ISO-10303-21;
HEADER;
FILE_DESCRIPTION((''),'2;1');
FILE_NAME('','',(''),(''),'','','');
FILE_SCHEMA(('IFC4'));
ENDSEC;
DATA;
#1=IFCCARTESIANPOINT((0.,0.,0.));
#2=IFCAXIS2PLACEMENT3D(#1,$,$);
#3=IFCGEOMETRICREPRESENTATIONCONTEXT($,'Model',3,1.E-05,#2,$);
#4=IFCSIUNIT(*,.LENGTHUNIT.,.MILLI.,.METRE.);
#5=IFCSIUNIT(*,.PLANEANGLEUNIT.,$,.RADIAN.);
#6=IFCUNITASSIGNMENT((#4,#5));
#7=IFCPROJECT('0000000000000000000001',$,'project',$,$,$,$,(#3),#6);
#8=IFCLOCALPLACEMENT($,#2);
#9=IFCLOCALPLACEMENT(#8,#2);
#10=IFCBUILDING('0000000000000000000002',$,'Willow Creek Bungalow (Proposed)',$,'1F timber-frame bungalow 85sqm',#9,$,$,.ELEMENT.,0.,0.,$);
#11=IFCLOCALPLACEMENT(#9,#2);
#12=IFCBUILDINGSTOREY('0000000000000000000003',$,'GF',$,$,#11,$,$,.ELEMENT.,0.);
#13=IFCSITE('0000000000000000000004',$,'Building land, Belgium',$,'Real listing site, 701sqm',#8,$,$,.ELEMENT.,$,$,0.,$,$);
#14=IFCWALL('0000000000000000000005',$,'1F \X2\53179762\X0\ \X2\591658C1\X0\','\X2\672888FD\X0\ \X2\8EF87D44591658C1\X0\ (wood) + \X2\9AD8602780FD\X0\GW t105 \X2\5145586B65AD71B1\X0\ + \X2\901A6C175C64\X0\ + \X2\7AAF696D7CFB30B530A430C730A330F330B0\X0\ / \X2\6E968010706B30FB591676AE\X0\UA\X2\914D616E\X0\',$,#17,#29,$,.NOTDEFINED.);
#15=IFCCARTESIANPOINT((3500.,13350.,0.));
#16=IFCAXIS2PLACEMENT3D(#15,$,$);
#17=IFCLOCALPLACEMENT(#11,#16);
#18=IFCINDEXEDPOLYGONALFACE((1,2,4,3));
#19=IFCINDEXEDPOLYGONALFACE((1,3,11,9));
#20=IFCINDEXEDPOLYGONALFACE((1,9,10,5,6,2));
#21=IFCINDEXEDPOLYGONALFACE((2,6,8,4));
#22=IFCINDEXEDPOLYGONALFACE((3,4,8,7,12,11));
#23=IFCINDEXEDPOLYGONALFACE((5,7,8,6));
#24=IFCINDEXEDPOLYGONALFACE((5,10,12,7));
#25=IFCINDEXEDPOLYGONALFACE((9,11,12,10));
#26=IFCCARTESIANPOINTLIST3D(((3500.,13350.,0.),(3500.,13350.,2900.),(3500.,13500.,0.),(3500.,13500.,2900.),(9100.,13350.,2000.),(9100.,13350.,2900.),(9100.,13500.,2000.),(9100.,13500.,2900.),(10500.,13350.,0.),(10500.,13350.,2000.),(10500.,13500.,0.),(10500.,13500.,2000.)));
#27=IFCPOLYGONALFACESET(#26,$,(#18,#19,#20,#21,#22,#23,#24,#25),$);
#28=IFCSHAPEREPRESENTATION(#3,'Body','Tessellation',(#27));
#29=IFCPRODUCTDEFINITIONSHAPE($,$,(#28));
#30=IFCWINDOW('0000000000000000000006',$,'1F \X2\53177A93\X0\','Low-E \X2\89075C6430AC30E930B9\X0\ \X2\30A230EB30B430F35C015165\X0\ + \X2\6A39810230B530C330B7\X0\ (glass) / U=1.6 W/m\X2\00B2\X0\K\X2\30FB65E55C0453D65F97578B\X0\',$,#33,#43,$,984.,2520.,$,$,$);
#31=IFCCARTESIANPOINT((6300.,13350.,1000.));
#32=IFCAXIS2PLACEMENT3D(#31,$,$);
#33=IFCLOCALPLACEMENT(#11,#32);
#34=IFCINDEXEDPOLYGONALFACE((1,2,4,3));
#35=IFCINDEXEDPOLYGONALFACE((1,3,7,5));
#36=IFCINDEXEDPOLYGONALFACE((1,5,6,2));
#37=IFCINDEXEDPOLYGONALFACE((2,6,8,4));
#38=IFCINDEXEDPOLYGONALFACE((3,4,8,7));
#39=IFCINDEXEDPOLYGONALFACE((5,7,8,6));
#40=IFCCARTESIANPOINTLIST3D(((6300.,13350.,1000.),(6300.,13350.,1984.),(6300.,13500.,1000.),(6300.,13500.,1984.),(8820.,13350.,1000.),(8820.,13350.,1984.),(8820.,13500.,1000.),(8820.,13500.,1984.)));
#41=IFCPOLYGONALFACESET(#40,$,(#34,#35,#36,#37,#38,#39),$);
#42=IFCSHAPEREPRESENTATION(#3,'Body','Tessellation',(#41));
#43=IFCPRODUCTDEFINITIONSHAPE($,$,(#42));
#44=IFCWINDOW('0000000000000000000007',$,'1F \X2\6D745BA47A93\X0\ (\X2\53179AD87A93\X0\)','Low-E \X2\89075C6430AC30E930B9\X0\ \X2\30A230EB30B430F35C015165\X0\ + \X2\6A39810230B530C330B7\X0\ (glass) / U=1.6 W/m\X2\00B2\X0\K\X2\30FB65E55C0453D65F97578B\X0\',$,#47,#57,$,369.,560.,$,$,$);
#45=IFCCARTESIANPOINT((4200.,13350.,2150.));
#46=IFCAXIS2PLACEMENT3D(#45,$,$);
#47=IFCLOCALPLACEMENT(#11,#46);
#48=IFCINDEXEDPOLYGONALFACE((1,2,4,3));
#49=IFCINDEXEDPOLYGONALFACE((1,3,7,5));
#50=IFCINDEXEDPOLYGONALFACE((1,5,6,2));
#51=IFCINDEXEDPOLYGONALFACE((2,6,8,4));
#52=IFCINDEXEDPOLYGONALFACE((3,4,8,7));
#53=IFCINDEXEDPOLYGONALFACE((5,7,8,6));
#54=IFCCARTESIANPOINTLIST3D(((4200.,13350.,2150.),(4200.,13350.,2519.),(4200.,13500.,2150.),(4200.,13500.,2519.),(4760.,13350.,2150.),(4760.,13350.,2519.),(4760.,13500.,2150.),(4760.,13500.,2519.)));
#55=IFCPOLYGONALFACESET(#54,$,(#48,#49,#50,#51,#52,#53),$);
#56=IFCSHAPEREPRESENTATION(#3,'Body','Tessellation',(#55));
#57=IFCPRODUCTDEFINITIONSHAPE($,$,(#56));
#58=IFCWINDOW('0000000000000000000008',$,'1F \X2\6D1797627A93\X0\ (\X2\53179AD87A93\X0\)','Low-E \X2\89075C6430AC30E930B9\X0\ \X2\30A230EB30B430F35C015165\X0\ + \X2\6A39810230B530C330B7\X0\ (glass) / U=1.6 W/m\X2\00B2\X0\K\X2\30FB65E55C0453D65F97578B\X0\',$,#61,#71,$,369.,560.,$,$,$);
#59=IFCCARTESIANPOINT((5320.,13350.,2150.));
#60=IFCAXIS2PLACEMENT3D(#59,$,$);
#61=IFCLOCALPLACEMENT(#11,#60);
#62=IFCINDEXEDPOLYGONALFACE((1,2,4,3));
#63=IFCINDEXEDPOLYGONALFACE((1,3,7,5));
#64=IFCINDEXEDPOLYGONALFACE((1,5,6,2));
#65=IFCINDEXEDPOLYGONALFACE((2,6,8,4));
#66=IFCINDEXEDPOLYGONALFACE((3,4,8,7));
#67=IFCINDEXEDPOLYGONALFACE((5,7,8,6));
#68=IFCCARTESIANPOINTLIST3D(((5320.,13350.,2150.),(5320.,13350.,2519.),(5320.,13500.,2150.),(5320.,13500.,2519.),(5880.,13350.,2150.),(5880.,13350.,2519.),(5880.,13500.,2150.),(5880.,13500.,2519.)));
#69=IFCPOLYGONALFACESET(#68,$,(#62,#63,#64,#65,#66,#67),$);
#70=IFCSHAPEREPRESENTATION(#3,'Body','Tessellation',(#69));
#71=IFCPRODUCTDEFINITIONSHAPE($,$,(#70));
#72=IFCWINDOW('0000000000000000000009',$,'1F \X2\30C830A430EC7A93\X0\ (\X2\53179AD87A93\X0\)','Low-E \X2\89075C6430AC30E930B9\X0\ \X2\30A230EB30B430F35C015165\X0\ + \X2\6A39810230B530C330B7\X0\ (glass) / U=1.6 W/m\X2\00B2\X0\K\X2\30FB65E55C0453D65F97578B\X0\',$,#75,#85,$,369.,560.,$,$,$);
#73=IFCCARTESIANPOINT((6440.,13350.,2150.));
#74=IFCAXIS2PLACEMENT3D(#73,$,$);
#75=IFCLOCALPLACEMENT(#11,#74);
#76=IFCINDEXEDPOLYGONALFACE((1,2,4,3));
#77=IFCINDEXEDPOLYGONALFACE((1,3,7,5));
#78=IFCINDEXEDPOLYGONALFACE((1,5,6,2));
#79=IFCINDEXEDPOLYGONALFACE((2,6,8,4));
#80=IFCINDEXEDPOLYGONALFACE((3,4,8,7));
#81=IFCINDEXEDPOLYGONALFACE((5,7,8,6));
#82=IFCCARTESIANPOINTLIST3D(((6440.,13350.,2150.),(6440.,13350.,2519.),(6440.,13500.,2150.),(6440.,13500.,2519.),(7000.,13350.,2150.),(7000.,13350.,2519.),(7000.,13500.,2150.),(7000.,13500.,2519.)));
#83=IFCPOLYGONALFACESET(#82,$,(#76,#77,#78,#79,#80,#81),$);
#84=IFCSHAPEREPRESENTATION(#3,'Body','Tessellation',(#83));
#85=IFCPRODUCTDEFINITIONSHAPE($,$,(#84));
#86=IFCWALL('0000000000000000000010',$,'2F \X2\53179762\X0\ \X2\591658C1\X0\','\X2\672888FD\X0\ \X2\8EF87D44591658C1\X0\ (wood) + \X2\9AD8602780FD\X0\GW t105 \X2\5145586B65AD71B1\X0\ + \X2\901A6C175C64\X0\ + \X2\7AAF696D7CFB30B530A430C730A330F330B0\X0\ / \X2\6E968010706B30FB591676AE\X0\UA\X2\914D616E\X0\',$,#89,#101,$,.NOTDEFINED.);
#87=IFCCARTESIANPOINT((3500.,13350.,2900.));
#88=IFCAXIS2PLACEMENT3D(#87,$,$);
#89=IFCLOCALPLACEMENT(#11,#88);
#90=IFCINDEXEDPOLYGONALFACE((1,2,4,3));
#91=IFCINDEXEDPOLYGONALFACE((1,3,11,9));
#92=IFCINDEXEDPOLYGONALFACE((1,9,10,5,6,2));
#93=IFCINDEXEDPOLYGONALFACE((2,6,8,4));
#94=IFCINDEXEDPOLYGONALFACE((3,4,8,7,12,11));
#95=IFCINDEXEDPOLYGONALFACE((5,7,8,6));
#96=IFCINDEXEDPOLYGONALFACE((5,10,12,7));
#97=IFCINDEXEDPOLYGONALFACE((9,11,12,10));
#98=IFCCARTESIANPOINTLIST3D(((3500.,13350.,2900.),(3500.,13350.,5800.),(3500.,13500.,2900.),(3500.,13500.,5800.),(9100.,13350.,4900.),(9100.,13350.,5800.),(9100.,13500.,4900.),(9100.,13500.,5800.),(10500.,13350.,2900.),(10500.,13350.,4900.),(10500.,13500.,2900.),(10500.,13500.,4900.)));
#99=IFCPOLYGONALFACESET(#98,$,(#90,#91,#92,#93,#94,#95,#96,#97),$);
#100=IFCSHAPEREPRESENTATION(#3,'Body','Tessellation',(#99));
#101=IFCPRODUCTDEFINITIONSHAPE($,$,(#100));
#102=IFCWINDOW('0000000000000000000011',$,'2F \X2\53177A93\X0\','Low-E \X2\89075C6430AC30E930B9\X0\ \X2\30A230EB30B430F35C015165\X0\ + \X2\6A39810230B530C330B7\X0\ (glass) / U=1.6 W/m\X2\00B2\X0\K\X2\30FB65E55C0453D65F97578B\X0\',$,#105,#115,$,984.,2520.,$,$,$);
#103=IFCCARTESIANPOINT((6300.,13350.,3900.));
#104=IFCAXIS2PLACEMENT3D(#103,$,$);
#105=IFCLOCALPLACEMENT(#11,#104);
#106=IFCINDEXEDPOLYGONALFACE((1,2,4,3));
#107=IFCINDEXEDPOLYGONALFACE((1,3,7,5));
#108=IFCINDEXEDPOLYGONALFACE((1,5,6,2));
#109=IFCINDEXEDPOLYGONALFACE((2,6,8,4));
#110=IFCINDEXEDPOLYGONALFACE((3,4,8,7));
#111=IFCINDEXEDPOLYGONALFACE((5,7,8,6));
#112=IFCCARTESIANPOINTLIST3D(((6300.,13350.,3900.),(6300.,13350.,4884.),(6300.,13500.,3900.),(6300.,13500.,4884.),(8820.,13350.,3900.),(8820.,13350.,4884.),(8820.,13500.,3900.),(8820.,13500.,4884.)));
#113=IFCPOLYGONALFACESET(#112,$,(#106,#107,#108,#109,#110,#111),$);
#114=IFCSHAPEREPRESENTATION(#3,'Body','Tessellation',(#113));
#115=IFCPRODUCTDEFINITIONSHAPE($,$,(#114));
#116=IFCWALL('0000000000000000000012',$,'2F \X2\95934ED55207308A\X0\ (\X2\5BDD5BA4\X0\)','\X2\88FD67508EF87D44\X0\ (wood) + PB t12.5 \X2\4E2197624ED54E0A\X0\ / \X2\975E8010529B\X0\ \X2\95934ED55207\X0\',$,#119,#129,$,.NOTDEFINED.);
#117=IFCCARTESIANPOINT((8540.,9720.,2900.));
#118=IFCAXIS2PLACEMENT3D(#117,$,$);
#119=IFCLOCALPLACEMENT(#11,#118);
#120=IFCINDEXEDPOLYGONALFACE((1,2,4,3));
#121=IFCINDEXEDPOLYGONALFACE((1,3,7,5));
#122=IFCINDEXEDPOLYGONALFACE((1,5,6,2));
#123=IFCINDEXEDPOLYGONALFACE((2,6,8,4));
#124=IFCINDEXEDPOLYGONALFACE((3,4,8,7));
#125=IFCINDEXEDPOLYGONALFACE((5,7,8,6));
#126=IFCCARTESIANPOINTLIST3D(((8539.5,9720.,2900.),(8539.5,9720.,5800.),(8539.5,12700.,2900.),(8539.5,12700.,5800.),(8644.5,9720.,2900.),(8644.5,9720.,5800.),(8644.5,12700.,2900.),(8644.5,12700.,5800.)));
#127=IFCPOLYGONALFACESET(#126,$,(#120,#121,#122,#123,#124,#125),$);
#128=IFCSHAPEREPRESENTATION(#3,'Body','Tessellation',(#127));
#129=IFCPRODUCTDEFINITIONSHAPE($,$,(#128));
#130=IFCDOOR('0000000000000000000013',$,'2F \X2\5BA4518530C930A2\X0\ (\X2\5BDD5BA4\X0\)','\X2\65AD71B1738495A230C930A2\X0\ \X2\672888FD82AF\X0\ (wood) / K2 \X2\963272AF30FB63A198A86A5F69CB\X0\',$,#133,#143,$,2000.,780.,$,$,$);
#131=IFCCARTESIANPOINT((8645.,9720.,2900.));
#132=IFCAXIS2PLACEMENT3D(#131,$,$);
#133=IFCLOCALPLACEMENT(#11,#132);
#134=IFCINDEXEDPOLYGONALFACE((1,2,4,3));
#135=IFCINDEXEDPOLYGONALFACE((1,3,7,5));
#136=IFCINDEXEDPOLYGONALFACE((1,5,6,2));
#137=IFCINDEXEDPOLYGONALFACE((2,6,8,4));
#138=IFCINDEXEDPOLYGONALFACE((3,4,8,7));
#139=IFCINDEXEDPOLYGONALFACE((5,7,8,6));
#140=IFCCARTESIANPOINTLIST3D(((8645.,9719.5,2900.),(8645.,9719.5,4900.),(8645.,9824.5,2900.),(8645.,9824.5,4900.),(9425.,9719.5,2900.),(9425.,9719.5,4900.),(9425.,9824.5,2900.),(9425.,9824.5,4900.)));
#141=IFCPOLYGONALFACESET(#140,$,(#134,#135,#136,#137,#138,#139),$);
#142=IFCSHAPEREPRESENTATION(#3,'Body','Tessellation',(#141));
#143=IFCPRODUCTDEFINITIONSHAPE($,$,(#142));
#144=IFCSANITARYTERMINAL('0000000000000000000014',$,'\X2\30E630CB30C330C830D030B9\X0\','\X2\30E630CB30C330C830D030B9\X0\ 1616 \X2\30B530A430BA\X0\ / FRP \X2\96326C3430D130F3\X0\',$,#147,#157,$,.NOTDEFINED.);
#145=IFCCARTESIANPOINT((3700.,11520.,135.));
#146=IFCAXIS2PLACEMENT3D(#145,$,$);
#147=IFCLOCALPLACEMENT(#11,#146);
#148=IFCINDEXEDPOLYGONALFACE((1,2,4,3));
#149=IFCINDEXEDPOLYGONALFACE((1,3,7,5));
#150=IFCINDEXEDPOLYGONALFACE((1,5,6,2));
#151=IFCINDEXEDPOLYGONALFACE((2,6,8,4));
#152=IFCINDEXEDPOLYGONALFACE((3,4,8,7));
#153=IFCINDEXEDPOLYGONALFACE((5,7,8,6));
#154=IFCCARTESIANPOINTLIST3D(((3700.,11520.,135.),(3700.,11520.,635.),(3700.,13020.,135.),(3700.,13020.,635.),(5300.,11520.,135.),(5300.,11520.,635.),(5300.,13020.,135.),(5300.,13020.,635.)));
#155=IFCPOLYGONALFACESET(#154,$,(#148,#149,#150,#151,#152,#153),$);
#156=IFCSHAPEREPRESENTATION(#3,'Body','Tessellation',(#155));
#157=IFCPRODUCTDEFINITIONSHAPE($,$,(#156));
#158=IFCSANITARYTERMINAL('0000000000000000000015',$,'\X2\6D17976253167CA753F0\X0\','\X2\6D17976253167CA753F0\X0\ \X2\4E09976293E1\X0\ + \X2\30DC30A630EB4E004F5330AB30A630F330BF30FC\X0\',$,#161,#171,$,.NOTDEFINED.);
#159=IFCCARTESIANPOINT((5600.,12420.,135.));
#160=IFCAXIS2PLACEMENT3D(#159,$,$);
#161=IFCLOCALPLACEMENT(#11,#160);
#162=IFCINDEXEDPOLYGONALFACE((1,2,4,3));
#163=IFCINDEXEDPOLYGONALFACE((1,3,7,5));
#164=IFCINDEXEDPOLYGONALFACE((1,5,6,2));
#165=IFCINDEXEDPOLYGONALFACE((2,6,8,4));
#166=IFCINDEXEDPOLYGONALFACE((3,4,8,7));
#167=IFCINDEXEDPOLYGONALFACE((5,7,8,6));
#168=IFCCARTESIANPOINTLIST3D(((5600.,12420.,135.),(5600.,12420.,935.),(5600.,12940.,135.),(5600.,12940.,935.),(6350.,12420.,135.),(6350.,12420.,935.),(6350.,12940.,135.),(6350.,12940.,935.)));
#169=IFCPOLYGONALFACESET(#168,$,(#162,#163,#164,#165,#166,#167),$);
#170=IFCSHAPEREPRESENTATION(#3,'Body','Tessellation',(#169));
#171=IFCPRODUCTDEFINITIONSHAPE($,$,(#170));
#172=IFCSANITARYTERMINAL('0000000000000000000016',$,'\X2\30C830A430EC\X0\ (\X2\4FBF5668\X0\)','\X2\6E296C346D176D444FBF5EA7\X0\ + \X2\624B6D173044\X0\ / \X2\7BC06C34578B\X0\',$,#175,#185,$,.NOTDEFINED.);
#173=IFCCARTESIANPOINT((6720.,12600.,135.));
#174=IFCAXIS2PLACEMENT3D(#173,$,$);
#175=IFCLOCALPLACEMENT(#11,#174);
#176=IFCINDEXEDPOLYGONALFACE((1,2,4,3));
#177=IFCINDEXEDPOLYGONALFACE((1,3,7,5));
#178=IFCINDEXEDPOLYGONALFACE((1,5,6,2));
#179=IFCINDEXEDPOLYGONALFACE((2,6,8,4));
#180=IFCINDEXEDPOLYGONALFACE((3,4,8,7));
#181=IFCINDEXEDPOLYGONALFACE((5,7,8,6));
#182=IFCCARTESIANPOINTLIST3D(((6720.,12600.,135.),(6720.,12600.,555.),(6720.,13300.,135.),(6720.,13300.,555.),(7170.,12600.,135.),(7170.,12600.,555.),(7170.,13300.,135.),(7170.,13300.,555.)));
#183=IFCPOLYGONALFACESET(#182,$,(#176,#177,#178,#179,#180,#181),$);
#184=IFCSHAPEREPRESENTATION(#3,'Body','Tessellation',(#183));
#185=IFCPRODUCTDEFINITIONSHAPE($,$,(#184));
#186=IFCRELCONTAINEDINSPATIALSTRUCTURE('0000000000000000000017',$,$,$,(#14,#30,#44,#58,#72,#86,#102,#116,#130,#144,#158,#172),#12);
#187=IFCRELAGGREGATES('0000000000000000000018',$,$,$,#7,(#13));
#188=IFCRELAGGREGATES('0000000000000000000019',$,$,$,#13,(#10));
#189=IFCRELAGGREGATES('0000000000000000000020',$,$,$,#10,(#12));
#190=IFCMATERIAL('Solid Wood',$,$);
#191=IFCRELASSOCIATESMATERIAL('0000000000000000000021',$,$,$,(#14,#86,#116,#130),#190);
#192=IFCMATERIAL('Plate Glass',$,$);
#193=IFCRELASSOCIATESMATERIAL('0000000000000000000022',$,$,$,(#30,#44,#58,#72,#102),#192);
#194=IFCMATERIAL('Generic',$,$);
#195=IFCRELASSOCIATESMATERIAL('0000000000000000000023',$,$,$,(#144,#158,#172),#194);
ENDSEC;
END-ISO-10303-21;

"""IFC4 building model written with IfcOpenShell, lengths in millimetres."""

from ifc_helpers import new_model, si_unit, frame, frame_2d, origin, place, context, project, spatial, rectangle, extrude, material, element, fill, save


model = new_model("IFC4")

# Units and contexts
model_context = context("Model", 3, precision=1e-05, world=origin())
ifc_project = project(units=[si_unit("LENGTHUNIT", "METRE", prefix="MILLI"), si_unit("PLANEANGLEUNIT", "RADIAN")], contexts=[model_context])

# Site, building, storey
site_placement = place(None, origin())
site = spatial("IfcSite", under=ifc_project, at=site_placement, Name="Building land, Belgium", ObjectType="Real listing site, 701sqm", CompositionType="ELEMENT", RefElevation=0.0)
building_placement = place(site_placement, origin())
building = spatial("IfcBuilding", under=site, at=building_placement, Name="Willow Creek Bungalow (Proposed)", ObjectType="1F timber-frame bungalow 85sqm", CompositionType="ELEMENT", ElevationOfRefHeight=0.0, ElevationOfTerrain=0.0)
storey_placement = place(building_placement, origin())
storey = spatial("IfcBuildingStorey", under=building, at=storey_placement, Name="GF", CompositionType="ELEMENT", Elevation=0.0)

# Wall, openings, windows
ifc_material_1 = material(Name="Solid Wood")
wall_1_placement = place(storey_placement, frame((3500.0, 13350.0, 0.0)))
wall_1 = element("IfcWall", 1, at=wall_1_placement, inside=storey, material=ifc_material_1, Name="1F 北面 外壁", Description="木製 軸組外壁 (wood) + 高性能GW t105 充填断熱 + 通気層 + 窯業系サイディング / 準耐火・外皮UA配慮", PredefinedType="NOTDEFINED", context=model_context, shape_type="SweptSolid", body=[
    extrude(rectangle(XDim=7000.0, YDim=150.0, at=frame_2d((3500.0, 75.0))), frame((3500.0, 13350.0, 0.0)), (0.0, 0.0, 1.0), 2900.0),
])
opening_1_placement = place(storey_placement, frame((6300.0, 13350.0, 1000.0)))
opening_1 = element("IfcOpeningElement", 2, at=opening_1_placement, cuts=wall_1, PredefinedType="NOTDEFINED", context=model_context, shape_type="SweptSolid", body=[
    extrude(rectangle(XDim=2520.0, YDim=150.0, at=frame_2d((1260.0, 75.0))), frame((6300.0, 13350.0, 1000.0)), (0.0, 0.0, 1.0), 984.0),
])
opening_2_placement = place(storey_placement, frame((4200.0, 13350.0, 2150.0)))
opening_2 = element("IfcOpeningElement", 3, at=opening_2_placement, cuts=wall_1, PredefinedType="NOTDEFINED", context=model_context, shape_type="SweptSolid", body=[
    extrude(rectangle(XDim=560.0, YDim=150.0, at=frame_2d((280.0, 75.0))), frame((4200.0, 13350.0, 2150.0)), (0.0, 0.0, 1.0), 369.0),
])
opening_3_placement = place(storey_placement, frame((5320.0, 13350.0, 2150.0)))
opening_3 = element("IfcOpeningElement", 4, at=opening_3_placement, cuts=wall_1, PredefinedType="NOTDEFINED", context=model_context, shape_type="SweptSolid", body=[
    extrude(rectangle(XDim=560.0, YDim=150.0, at=frame_2d((280.0, 75.0))), frame((5320.0, 13350.0, 2150.0)), (0.0, 0.0, 1.0), 369.0),
])
opening_4_placement = place(storey_placement, frame((6440.0, 13350.0, 2150.0)))
opening_4 = element("IfcOpeningElement", 5, at=opening_4_placement, cuts=wall_1, PredefinedType="NOTDEFINED", context=model_context, shape_type="SweptSolid", body=[
    extrude(rectangle(XDim=560.0, YDim=150.0, at=frame_2d((280.0, 75.0))), frame((6440.0, 13350.0, 2150.0)), (0.0, 0.0, 1.0), 369.0),
])
ifc_material_2 = material(Name="Plate Glass")
window_1_placement = place(storey_placement, frame((6300.0, 13350.0, 1000.0)))
window_1 = element("IfcWindow", 6, at=window_1_placement, inside=storey, material=ifc_material_2, Name="1F 北窓", Description="Low-E 複層ガラス アルゴン封入 + 樹脂サッシ (glass) / U=1.6 W/m²K・日射取得型", OverallHeight=984.0, OverallWidth=2520.0, context=model_context, shape_type="SweptSolid", body=[
    extrude(rectangle(XDim=2520.0, YDim=150.0, at=frame_2d((1260.0, 75.0))), frame((6300.0, 13350.0, 1000.0)), (0.0, 0.0, 1.0), 984.0),
])
fill(opening_1, window_1)
window_2_placement = place(storey_placement, frame((4200.0, 13350.0, 2150.0)))
window_2 = element("IfcWindow", 7, at=window_2_placement, inside=storey, material=ifc_material_2, Name="1F 浴室窓 (北高窓)", Description="Low-E 複層ガラス アルゴン封入 + 樹脂サッシ (glass) / U=1.6 W/m²K・日射取得型", OverallHeight=369.0, OverallWidth=560.0, context=model_context, shape_type="SweptSolid", body=[
    extrude(rectangle(XDim=560.0, YDim=150.0, at=frame_2d((280.0, 75.0))), frame((4200.0, 13350.0, 2150.0)), (0.0, 0.0, 1.0), 369.0),
])
fill(opening_2, window_2)
window_3_placement = place(storey_placement, frame((5320.0, 13350.0, 2150.0)))
window_3 = element("IfcWindow", 8, at=window_3_placement, inside=storey, material=ifc_material_2, Name="1F 洗面窓 (北高窓)", Description="Low-E 複層ガラス アルゴン封入 + 樹脂サッシ (glass) / U=1.6 W/m²K・日射取得型", OverallHeight=369.0, OverallWidth=560.0, context=model_context, shape_type="SweptSolid", body=[
    extrude(rectangle(XDim=560.0, YDim=150.0, at=frame_2d((280.0, 75.0))), frame((5320.0, 13350.0, 2150.0)), (0.0, 0.0, 1.0), 369.0),
])
fill(opening_3, window_3)
window_4_placement = place(storey_placement, frame((6440.0, 13350.0, 2150.0)))
window_4 = element("IfcWindow", 9, at=window_4_placement, inside=storey, material=ifc_material_2, Name="1F トイレ窓 (北高窓)", Description="Low-E 複層ガラス アルゴン封入 + 樹脂サッシ (glass) / U=1.6 W/m²K・日射取得型", OverallHeight=369.0, OverallWidth=560.0, context=model_context, shape_type="SweptSolid", body=[
    extrude(rectangle(XDim=560.0, YDim=150.0, at=frame_2d((280.0, 75.0))), frame((6440.0, 13350.0, 2150.0)), (0.0, 0.0, 1.0), 369.0),
])
fill(opening_4, window_4)

# Wall, opening, window
wall_2_placement = place(storey_placement, frame((3500.0, 13350.0, 2900.0)))
wall_2 = element("IfcWall", 10, at=wall_2_placement, inside=storey, material=ifc_material_1, Name="2F 北面 外壁", Description="木製 軸組外壁 (wood) + 高性能GW t105 充填断熱 + 通気層 + 窯業系サイディング / 準耐火・外皮UA配慮", PredefinedType="NOTDEFINED", context=model_context, shape_type="SweptSolid", body=[
    extrude(rectangle(XDim=7000.0, YDim=150.0, at=frame_2d((3500.0, 75.0))), frame((3500.0, 13350.0, 2900.0)), (0.0, 0.0, 1.0), 2900.0),
])
opening_5_placement = place(storey_placement, frame((6300.0, 13350.0, 3900.0)))
opening_5 = element("IfcOpeningElement", 11, at=opening_5_placement, cuts=wall_2, PredefinedType="NOTDEFINED", context=model_context, shape_type="SweptSolid", body=[
    extrude(rectangle(XDim=2520.0, YDim=150.0, at=frame_2d((1260.0, 75.0))), frame((6300.0, 13350.0, 3900.0)), (0.0, 0.0, 1.0), 984.0),
])
window_5_placement = place(storey_placement, frame((6300.0, 13350.0, 3900.0)))
window_5 = element("IfcWindow", 12, at=window_5_placement, inside=storey, material=ifc_material_2, Name="2F 北窓", Description="Low-E 複層ガラス アルゴン封入 + 樹脂サッシ (glass) / U=1.6 W/m²K・日射取得型", OverallHeight=984.0, OverallWidth=2520.0, context=model_context, shape_type="SweptSolid", body=[
    extrude(rectangle(XDim=2520.0, YDim=150.0, at=frame_2d((1260.0, 75.0))), frame((6300.0, 13350.0, 3900.0)), (0.0, 0.0, 1.0), 984.0),
])
fill(opening_5, window_5)

# Wall
wall_3_placement = place(storey_placement, frame((8540.0, 9720.0, 2900.0)))
element("IfcWall", 13, at=wall_3_placement, inside=storey, material=ifc_material_1, Name="2F 間仕切り (寝室)", Description="製材軸組 (wood) + PB t12.5 両面仕上 / 非耐力 間仕切", PredefinedType="NOTDEFINED", context=model_context, shape_type="SweptSolid", body=[
    extrude(rectangle(XDim=105.0, YDim=2980.0, at=frame_2d((52.0, 1490.0))), frame((8540.0, 9720.0, 2900.0)), (0.0, 0.0, 1.0), 2900.0),
])

# Door
door_1_placement = place(storey_placement, frame((8645.0, 9720.0, 2900.0)))
element("IfcDoor", 14, at=door_1_placement, inside=storey, material=ifc_material_1, Name="2F 室内ドア (寝室)", Description="断熱玄関ドア 木製芯 (wood) / K2 防犯・採風機構", OverallHeight=2000.0, OverallWidth=780.0, context=model_context, shape_type="SweptSolid", body=[
    extrude(rectangle(XDim=780.0, YDim=105.0, at=frame_2d((390.0, 52.0))), frame((8645.0, 9720.0, 2900.0)), (0.0, 0.0, 1.0), 2000.0),
])

# Sanitary terminals
ifc_material_3 = material(Name="Generic")
sanitary_terminal_1_placement = place(storey_placement, frame((3700.0, 11520.0, 135.0)))
element("IfcSanitaryTerminal", 15, at=sanitary_terminal_1_placement, inside=storey, material=ifc_material_3, Name="ユニットバス", Description="ユニットバス 1616 サイズ / FRP 防水パン", PredefinedType="NOTDEFINED", context=model_context, shape_type="SweptSolid", body=[
    extrude(rectangle(XDim=1600.0, YDim=1500.0, at=frame_2d((800.0, 750.0))), frame((3700.0, 11520.0, 135.0)), (0.0, 0.0, 1.0), 500.0),
])
sanitary_terminal_2_placement = place(storey_placement, frame((5600.0, 12420.0, 135.0)))
element("IfcSanitaryTerminal", 16, at=sanitary_terminal_2_placement, inside=storey, material=ifc_material_3, Name="洗面化粧台", Description="洗面化粧台 三面鏡 + ボウル一体カウンター", PredefinedType="NOTDEFINED", context=model_context, shape_type="SweptSolid", body=[
    extrude(rectangle(XDim=750.0, YDim=520.0, at=frame_2d((375.0, 260.0))), frame((5600.0, 12420.0, 135.0)), (0.0, 0.0, 1.0), 800.0),
])
sanitary_terminal_3_placement = place(storey_placement, frame((6720.0, 12600.0, 135.0)))
element("IfcSanitaryTerminal", 17, at=sanitary_terminal_3_placement, inside=storey, material=ifc_material_3, Name="トイレ (便器)", Description="温水洗浄便座 + 手洗い / 節水型", PredefinedType="NOTDEFINED", context=model_context, shape_type="SweptSolid", body=[
    extrude(rectangle(XDim=450.0, YDim=700.0, at=frame_2d((225.0, 350.0))), frame((6720.0, 12600.0, 135.0)), (0.0, 0.0, 1.0), 420.0),
])

save(model, "model.ifc")
